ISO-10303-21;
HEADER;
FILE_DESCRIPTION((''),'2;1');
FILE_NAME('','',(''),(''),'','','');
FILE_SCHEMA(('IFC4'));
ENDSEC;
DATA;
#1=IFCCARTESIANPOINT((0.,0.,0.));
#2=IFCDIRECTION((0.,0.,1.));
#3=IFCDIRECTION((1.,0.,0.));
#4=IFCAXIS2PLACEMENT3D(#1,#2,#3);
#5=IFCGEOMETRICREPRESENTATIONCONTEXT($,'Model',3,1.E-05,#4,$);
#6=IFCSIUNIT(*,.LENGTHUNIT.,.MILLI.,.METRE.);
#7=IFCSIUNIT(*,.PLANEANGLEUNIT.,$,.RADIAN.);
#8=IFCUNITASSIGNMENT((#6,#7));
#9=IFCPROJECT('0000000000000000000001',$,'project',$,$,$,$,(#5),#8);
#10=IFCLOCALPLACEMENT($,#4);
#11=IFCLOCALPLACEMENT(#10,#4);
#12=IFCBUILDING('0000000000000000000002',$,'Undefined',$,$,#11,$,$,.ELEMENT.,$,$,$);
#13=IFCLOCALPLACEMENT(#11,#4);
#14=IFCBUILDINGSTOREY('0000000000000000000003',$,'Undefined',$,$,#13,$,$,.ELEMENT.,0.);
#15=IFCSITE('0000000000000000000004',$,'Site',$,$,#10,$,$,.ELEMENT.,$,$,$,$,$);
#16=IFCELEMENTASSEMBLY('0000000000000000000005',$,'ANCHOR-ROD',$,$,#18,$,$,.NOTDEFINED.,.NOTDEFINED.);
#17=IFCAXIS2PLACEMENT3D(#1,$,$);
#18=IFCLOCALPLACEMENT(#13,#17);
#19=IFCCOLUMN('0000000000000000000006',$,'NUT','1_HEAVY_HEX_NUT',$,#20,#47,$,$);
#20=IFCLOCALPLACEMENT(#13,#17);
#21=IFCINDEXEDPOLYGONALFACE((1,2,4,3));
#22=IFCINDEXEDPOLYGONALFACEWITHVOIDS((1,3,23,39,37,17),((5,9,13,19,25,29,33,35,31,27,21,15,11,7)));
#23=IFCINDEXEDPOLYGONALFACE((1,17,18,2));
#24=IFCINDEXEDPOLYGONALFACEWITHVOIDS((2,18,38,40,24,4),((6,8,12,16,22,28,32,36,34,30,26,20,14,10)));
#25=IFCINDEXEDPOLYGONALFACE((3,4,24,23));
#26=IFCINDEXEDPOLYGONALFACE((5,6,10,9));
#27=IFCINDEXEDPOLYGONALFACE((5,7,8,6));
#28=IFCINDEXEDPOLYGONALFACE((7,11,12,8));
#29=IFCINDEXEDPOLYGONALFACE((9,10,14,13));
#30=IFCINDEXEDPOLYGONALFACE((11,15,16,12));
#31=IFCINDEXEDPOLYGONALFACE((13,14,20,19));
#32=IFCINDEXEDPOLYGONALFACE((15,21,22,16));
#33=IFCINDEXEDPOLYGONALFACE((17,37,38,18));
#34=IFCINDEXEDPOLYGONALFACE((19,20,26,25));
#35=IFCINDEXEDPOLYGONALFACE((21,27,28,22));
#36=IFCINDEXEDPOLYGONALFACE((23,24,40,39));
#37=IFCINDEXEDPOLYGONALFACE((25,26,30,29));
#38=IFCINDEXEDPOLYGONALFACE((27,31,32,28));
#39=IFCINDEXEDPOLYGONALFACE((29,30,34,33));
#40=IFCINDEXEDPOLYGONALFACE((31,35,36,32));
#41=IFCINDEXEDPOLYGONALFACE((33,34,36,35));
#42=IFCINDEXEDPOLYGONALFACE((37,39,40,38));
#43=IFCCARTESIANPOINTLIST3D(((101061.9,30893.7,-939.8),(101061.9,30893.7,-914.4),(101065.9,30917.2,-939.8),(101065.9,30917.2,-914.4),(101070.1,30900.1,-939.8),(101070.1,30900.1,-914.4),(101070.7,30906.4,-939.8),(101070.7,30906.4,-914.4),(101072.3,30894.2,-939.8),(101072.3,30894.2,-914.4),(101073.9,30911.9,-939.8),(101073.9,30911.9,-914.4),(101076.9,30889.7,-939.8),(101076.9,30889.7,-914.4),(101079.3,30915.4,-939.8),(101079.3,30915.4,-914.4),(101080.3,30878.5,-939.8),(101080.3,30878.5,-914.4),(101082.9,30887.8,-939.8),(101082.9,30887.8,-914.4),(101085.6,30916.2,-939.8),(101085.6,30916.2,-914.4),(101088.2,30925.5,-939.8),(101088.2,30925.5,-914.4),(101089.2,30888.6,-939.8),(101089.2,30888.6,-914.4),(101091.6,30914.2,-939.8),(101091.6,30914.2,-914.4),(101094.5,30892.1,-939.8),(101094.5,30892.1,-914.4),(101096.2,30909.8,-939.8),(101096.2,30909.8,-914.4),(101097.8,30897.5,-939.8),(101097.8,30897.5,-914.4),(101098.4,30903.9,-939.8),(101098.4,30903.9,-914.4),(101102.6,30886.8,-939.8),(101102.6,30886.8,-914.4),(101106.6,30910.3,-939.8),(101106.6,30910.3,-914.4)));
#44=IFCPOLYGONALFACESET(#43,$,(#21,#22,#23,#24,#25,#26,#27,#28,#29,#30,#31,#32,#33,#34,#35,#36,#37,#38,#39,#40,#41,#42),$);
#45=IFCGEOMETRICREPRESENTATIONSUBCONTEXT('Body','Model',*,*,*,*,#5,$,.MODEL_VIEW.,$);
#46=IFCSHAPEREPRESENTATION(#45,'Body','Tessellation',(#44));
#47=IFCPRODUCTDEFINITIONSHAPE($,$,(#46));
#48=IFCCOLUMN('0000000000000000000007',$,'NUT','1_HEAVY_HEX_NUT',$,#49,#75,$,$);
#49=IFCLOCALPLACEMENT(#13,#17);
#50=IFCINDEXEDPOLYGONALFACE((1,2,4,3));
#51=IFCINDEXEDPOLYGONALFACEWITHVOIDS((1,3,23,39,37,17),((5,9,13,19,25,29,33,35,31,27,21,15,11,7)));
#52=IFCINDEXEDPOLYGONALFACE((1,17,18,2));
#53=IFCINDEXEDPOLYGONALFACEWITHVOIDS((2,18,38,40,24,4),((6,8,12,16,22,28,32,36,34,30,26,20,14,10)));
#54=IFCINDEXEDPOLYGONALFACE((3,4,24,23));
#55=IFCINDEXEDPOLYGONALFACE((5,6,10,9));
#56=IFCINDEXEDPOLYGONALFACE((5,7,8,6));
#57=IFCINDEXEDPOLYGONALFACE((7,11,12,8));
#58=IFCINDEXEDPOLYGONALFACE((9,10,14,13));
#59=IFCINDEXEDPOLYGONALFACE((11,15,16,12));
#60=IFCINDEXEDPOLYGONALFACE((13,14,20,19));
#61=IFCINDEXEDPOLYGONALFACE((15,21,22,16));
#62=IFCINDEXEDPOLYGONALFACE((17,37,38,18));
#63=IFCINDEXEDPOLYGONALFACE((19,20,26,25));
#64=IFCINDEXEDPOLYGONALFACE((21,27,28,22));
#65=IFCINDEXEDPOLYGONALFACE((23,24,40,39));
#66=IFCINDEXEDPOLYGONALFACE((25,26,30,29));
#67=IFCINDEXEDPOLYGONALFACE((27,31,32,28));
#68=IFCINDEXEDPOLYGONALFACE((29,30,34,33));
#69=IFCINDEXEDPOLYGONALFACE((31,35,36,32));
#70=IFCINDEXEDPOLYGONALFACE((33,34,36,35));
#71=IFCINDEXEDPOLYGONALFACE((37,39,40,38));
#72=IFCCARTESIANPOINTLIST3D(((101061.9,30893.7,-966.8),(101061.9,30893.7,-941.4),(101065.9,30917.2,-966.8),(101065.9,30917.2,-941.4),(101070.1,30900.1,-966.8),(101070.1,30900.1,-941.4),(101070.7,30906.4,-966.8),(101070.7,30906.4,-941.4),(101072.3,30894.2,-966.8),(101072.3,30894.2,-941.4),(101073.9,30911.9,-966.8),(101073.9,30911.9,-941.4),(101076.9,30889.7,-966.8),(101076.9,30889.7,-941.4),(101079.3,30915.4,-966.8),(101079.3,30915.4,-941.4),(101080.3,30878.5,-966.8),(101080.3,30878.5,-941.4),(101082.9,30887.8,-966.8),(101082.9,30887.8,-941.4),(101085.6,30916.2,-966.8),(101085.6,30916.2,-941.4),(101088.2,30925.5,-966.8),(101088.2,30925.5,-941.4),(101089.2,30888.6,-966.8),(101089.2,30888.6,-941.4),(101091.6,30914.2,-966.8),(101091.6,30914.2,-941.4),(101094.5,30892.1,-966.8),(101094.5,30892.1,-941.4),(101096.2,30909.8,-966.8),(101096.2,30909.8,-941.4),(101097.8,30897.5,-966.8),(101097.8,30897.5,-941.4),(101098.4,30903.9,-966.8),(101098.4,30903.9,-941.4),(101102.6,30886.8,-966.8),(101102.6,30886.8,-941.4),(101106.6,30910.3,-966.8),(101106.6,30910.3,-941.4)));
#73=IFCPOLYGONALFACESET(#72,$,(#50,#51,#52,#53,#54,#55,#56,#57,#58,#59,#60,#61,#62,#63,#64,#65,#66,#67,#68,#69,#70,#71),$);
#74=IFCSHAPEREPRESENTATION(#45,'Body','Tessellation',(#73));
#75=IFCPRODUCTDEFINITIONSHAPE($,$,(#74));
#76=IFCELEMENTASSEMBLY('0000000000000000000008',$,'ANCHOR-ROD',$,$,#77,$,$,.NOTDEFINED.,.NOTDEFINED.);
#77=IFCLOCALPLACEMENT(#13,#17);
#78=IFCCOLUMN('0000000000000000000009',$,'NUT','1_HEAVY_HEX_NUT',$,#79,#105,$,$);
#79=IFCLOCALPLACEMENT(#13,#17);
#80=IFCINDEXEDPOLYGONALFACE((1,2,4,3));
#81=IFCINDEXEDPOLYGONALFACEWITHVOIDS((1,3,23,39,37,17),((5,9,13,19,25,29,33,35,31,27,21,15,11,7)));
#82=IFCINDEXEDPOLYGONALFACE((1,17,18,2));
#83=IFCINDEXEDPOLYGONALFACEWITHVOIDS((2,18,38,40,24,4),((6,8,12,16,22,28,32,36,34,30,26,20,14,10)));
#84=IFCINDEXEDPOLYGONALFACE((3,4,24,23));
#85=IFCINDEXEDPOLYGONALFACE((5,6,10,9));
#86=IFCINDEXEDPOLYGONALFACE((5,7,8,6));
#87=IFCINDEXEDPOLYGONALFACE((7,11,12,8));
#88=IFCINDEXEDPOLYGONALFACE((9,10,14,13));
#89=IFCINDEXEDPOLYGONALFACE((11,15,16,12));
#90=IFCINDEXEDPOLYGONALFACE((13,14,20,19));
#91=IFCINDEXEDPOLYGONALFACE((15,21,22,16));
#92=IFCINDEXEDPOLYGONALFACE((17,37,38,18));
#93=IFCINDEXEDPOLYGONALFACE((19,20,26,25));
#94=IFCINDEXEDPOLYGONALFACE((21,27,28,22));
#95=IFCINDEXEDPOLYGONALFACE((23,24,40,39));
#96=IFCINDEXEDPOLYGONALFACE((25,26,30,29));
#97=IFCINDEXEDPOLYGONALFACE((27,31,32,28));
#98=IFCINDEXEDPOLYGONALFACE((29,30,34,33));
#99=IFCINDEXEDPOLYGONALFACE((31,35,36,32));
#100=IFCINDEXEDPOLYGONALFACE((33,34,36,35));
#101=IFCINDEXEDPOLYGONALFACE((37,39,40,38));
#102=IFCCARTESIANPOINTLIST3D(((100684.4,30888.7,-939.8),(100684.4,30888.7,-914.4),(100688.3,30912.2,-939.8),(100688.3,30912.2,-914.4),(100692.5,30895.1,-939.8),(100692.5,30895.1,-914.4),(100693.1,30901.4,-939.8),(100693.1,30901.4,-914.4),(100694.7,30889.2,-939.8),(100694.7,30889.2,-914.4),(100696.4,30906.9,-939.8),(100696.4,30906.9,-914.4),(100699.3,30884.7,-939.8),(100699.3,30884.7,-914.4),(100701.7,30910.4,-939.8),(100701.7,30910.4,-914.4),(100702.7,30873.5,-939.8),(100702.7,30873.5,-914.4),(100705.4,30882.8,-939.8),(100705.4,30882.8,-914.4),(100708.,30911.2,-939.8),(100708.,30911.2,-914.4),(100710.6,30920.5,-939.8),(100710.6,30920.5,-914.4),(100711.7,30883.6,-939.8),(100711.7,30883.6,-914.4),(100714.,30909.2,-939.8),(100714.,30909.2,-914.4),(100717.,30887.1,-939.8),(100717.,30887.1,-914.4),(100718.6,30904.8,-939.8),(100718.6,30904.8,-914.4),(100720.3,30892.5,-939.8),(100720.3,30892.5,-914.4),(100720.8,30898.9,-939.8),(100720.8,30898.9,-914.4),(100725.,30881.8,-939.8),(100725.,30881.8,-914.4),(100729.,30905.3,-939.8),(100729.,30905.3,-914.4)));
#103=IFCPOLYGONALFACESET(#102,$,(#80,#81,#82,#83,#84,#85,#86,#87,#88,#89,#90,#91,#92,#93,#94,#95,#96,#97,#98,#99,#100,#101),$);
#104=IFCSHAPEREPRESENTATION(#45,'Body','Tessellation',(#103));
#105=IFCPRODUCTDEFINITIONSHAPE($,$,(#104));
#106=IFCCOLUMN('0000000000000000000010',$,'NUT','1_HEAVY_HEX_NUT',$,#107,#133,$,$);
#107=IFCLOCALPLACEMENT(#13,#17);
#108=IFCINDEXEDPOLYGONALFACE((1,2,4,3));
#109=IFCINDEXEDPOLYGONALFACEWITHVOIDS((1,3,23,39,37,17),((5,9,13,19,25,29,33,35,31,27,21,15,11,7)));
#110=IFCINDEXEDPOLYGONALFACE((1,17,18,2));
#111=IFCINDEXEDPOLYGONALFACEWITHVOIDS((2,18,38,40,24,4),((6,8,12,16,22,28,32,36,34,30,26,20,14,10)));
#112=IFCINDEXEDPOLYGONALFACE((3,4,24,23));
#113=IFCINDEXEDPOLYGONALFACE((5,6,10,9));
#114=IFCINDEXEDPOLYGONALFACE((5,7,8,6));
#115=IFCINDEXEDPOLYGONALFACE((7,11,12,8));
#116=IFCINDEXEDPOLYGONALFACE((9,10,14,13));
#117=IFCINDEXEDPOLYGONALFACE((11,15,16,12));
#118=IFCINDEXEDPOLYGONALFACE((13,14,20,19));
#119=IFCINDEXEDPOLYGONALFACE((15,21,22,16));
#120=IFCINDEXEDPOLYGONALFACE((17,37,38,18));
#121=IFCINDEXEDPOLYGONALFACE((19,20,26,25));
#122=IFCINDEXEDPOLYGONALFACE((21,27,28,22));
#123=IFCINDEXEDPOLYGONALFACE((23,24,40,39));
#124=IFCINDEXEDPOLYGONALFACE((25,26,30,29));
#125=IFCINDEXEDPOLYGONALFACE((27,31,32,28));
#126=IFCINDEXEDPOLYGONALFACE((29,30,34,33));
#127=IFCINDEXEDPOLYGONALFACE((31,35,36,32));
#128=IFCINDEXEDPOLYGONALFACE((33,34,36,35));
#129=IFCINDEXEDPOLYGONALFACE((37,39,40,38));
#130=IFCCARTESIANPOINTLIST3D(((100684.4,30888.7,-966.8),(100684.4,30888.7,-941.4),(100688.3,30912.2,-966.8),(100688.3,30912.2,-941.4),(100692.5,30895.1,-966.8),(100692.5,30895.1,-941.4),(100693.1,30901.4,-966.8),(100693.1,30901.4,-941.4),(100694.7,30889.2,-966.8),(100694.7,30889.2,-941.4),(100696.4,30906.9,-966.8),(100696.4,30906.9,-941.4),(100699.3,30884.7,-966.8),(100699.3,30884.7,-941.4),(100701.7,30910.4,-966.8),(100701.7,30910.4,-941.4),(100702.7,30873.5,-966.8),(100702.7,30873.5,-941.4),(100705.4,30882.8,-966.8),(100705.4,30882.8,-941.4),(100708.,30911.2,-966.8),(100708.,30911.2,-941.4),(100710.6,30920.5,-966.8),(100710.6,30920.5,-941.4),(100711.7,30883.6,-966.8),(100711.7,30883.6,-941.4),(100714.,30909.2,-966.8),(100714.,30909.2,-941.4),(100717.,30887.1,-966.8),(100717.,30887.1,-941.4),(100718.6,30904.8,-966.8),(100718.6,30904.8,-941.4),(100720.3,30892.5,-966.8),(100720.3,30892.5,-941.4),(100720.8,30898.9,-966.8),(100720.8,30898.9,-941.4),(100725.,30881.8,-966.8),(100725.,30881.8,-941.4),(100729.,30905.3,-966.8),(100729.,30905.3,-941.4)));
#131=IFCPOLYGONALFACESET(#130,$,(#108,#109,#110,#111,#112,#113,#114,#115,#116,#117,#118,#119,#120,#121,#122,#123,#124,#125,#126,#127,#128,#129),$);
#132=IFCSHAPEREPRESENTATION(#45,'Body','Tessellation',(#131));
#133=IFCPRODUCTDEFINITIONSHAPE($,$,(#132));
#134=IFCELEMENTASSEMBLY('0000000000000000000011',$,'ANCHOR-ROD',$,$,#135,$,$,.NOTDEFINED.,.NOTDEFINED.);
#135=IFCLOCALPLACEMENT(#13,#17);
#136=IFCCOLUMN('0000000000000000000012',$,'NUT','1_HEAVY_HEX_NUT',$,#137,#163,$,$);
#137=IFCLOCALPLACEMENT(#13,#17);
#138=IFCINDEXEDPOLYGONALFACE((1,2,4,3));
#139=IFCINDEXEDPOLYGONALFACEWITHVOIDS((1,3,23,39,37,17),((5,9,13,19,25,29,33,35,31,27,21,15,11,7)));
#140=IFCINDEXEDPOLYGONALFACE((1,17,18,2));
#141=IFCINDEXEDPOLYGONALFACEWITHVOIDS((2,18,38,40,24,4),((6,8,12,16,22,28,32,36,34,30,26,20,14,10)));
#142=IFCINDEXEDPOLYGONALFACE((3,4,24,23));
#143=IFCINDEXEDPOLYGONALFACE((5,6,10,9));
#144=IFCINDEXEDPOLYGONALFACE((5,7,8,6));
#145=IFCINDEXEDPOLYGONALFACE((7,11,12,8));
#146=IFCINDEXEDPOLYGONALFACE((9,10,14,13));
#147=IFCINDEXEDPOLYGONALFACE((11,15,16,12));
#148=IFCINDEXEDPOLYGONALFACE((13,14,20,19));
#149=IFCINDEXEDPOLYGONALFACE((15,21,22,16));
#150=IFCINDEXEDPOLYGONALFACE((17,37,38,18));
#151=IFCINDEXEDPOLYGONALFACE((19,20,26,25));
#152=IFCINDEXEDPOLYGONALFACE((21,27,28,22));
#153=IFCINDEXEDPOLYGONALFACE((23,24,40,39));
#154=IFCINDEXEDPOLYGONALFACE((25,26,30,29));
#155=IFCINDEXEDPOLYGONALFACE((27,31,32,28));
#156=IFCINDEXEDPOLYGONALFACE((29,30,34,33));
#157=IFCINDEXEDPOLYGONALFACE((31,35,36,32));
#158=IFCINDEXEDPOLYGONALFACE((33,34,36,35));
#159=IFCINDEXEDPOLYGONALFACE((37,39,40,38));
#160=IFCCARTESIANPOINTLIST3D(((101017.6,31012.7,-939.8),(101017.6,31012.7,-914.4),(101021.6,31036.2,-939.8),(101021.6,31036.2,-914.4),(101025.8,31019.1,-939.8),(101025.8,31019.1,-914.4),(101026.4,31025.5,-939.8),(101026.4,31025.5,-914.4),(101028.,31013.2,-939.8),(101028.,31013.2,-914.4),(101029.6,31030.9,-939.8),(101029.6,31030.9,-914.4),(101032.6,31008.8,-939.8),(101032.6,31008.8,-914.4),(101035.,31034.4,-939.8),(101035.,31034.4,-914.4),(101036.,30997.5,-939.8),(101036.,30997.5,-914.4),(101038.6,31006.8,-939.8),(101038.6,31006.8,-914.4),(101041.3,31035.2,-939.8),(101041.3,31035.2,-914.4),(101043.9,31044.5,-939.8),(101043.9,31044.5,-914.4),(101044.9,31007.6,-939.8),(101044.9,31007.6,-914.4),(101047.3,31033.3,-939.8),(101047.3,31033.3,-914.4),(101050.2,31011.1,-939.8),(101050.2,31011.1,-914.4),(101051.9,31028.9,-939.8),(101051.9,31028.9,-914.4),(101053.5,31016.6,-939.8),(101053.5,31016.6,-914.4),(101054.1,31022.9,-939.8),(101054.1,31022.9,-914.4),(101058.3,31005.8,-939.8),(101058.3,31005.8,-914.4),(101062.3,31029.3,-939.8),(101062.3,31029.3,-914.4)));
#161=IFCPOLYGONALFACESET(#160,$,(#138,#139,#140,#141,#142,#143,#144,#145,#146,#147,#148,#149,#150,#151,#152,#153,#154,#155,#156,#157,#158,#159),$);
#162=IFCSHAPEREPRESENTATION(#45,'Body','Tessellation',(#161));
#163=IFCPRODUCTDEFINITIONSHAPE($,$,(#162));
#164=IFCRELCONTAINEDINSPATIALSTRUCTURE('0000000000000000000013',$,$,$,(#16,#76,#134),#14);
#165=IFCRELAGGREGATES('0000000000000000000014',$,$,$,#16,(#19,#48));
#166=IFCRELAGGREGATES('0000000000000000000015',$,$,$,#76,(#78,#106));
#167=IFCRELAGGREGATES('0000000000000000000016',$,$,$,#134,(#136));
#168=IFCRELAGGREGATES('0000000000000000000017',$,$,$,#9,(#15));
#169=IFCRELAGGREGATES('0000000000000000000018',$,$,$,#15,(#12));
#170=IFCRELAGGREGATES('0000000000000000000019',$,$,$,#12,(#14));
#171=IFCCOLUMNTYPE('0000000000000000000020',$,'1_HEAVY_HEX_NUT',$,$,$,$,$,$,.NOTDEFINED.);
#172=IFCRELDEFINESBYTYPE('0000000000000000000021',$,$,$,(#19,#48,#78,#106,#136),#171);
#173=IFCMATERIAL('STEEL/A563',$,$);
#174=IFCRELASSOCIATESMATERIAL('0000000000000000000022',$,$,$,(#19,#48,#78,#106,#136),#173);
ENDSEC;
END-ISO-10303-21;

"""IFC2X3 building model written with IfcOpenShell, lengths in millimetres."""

from ifc_helpers import new_model, si_unit, frame, origin_with_axes, place, context, subcontext, project, spatial, polyline, outline, extrude, material, type_object, element, aggregate, save


model = new_model("IFC2X3")

# Units and contexts
model_context = context("Model", 3, precision=1e-05, world=origin_with_axes())
body_context = subcontext(model_context, "Body", "Model", "MODEL_VIEW")
ifc_project = project(units=[si_unit("LENGTHUNIT", "METRE", prefix="MILLI"), si_unit("PLANEANGLEUNIT", "RADIAN")], contexts=[model_context])

# Site, building, storey
site_placement = place(None, origin_with_axes())
site = spatial("IfcSite", under=ifc_project, at=site_placement, Name="Site", CompositionType="ELEMENT")
building_placement = place(site_placement, origin_with_axes())
building = spatial("IfcBuilding", under=site, at=building_placement, Name="Undefined", CompositionType="ELEMENT")
storey_placement = place(building_placement, origin_with_axes())
storey = spatial("IfcBuildingStorey", under=building, at=storey_placement, Name="Undefined", CompositionType="ELEMENT", Elevation=0.0)

# Element assemblies, columns
assembly_1_placement = place(storey_placement, origin_with_axes())
assembly_1 = element("IfcElementAssembly", 1, at=assembly_1_placement, inside=storey, Name="ANCHOR-ROD", AssemblyPlace="NOTDEFINED", PredefinedType="NOTDEFINED")
ifc_material_1 = material(Name="STEEL/A563")
column_type_1 = type_object("IfcColumnType", Name="1_HEAVY_HEX_NUT", PredefinedType="NOTDEFINED")
column_1_placement = place(assembly_1_placement, frame((101084.2, 30902.0, -914.4), z_axis=(0.0, 0.0, -1.0), x_axis=(-0.34879, 0.937201, 0.0)))
column_1 = element("IfcColumn", 2, at=column_1_placement, type_object=column_type_1, material=ifc_material_1, Name="NUT", Description="1_HEAVY_HEX_NUT", context=body_context, shape_type="SweptSolid", body=[
    extrude(outline(polyline([(-11.9, -20.6), (-23.8, 0.0), (-11.9, 20.6), (11.9, 20.6), (23.8, 0.0), (11.9, -20.6), (-11.9, -20.6)]), holes=[polyline([(11.2, 8.9), (6.2, 12.9), (0.0, 14.3), (-6.2, 12.9), (-11.2, 8.9), (-13.9, 3.2), (-13.9, -3.2), (-11.2, -8.9), (-6.2, -12.9), (0.0, -14.3), (6.2, -12.9), (11.2, -8.9), (13.9, -3.2), (13.9, 3.2), (11.2, 8.9)])]), frame((0.0, 0.0, 25.4), z_axis=(0.0, 0.0, -1.0), x_axis=(0.0, 1.0, 0.0)), (0.0, 0.0, 1.0), 25.4),
])
column_2_placement = place(assembly_1_placement, frame((101084.2, 30902.0, -941.4), z_axis=(0.0, 0.0, -1.0), x_axis=(-0.34879, 0.937201, 0.0)))
column_2 = element("IfcColumn", 3, at=column_2_placement, type_object=column_type_1, material=ifc_material_1, Name="NUT", Description="1_HEAVY_HEX_NUT", context=body_context, shape_type="SweptSolid", body=[
    extrude(outline(polyline([(-11.9, -20.6), (-23.8, 0.0), (-11.9, 20.6), (11.9, 20.6), (23.8, 0.0), (11.9, -20.6), (-11.9, -20.6)]), holes=[polyline([(11.2, 8.9), (6.2, 12.9), (0.0, 14.3), (-6.2, 12.9), (-11.2, 8.9), (-13.9, 3.2), (-13.9, -3.2), (-11.2, -8.9), (-6.2, -12.9), (0.0, -14.3), (6.2, -12.9), (11.2, -8.9), (13.9, -3.2), (13.9, 3.2), (11.2, 8.9)])]), frame((0.0, 0.0, 25.4), z_axis=(0.0, 0.0, -1.0), x_axis=(0.0, 1.0, 0.0)), (0.0, 0.0, 1.0), 25.4),
])
aggregate(assembly_1, [column_1, column_2])
assembly_2_placement = place(storey_placement, origin_with_axes())
assembly_2 = element("IfcElementAssembly", 4, at=assembly_2_placement, inside=storey, Name="ANCHOR-ROD", AssemblyPlace="NOTDEFINED", PredefinedType="NOTDEFINED")
column_3_placement = place(assembly_2_placement, frame((100706.7, 30897.0, -914.4), z_axis=(0.0, 0.0, -1.0), x_axis=(0.34879, -0.937201, 0.0)))
column_3 = element("IfcColumn", 5, at=column_3_placement, type_object=column_type_1, material=ifc_material_1, Name="NUT", Description="1_HEAVY_HEX_NUT", context=body_context, shape_type="SweptSolid", body=[
    extrude(outline(polyline([(-11.9, -20.6), (-23.8, 0.0), (-11.9, 20.6), (11.9, 20.6), (23.8, 0.0), (11.9, -20.6), (-11.9, -20.6)]), holes=[polyline([(11.2, 8.9), (6.2, 12.9), (0.0, 14.3), (-6.2, 12.9), (-11.2, 8.9), (-13.9, 3.2), (-13.9, -3.2), (-11.2, -8.9), (-6.2, -12.9), (0.0, -14.3), (6.2, -12.9), (11.2, -8.9), (13.9, -3.2), (13.9, 3.2), (11.2, 8.9)])]), frame((0.0, 0.0, 25.4), z_axis=(0.0, 0.0, -1.0), x_axis=(0.0, 1.0, 0.0)), (0.0, 0.0, 1.0), 25.4),
])
column_4_placement = place(assembly_2_placement, frame((100706.7, 30897.0, -941.4), z_axis=(0.0, 0.0, -1.0), x_axis=(0.34879, -0.937201, 0.0)))
column_4 = element("IfcColumn", 6, at=column_4_placement, type_object=column_type_1, material=ifc_material_1, Name="NUT", Description="1_HEAVY_HEX_NUT", context=body_context, shape_type="SweptSolid", body=[
    extrude(outline(polyline([(-11.9, -20.6), (-23.8, 0.0), (-11.9, 20.6), (11.9, 20.6), (23.8, 0.0), (11.9, -20.6), (-11.9, -20.6)]), holes=[polyline([(11.2, 8.9), (6.2, 12.9), (0.0, 14.3), (-6.2, 12.9), (-11.2, 8.9), (-13.9, 3.2), (-13.9, -3.2), (-11.2, -8.9), (-6.2, -12.9), (0.0, -14.3), (6.2, -12.9), (11.2, -8.9), (13.9, -3.2), (13.9, 3.2), (11.2, 8.9)])]), frame((0.0, 0.0, 25.4), z_axis=(0.0, 0.0, -1.0), x_axis=(0.0, 1.0, 0.0)), (0.0, 0.0, 1.0), 25.4),
])
aggregate(assembly_2, [column_3, column_4])
assembly_3_placement = place(storey_placement, origin_with_axes())
assembly_3 = element("IfcElementAssembly", 7, at=assembly_3_placement, inside=storey, Name="ANCHOR-ROD", AssemblyPlace="NOTDEFINED", PredefinedType="NOTDEFINED")
column_5_placement = place(assembly_3_placement, frame((101039.9, 31021.0, -914.4), z_axis=(0.0, 0.0, -1.0), x_axis=(-0.34879, 0.937201, 0.0)))
column_5 = element("IfcColumn", 8, at=column_5_placement, type_object=column_type_1, material=ifc_material_1, Name="NUT", Description="1_HEAVY_HEX_NUT", context=body_context, shape_type="SweptSolid", body=[
    extrude(outline(polyline([(-11.9, -20.6), (-23.8, 0.0), (-11.9, 20.6), (11.9, 20.6), (23.8, 0.0), (11.9, -20.6), (-11.9, -20.6)]), holes=[polyline([(11.2, 8.9), (6.2, 12.9), (0.0, 14.3), (-6.2, 12.9), (-11.2, 8.9), (-13.9, 3.2), (-13.9, -3.2), (-11.2, -8.9), (-6.2, -12.9), (0.0, -14.3), (6.2, -12.9), (11.2, -8.9), (13.9, -3.2), (13.9, 3.2), (11.2, 8.9)])]), frame((0.0, 0.0, 25.4), z_axis=(0.0, 0.0, -1.0), x_axis=(0.0, 1.0, 0.0)), (0.0, 0.0, 1.0), 25.4),
])
aggregate(assembly_3, [column_5])

save(model, "model.ifc")
